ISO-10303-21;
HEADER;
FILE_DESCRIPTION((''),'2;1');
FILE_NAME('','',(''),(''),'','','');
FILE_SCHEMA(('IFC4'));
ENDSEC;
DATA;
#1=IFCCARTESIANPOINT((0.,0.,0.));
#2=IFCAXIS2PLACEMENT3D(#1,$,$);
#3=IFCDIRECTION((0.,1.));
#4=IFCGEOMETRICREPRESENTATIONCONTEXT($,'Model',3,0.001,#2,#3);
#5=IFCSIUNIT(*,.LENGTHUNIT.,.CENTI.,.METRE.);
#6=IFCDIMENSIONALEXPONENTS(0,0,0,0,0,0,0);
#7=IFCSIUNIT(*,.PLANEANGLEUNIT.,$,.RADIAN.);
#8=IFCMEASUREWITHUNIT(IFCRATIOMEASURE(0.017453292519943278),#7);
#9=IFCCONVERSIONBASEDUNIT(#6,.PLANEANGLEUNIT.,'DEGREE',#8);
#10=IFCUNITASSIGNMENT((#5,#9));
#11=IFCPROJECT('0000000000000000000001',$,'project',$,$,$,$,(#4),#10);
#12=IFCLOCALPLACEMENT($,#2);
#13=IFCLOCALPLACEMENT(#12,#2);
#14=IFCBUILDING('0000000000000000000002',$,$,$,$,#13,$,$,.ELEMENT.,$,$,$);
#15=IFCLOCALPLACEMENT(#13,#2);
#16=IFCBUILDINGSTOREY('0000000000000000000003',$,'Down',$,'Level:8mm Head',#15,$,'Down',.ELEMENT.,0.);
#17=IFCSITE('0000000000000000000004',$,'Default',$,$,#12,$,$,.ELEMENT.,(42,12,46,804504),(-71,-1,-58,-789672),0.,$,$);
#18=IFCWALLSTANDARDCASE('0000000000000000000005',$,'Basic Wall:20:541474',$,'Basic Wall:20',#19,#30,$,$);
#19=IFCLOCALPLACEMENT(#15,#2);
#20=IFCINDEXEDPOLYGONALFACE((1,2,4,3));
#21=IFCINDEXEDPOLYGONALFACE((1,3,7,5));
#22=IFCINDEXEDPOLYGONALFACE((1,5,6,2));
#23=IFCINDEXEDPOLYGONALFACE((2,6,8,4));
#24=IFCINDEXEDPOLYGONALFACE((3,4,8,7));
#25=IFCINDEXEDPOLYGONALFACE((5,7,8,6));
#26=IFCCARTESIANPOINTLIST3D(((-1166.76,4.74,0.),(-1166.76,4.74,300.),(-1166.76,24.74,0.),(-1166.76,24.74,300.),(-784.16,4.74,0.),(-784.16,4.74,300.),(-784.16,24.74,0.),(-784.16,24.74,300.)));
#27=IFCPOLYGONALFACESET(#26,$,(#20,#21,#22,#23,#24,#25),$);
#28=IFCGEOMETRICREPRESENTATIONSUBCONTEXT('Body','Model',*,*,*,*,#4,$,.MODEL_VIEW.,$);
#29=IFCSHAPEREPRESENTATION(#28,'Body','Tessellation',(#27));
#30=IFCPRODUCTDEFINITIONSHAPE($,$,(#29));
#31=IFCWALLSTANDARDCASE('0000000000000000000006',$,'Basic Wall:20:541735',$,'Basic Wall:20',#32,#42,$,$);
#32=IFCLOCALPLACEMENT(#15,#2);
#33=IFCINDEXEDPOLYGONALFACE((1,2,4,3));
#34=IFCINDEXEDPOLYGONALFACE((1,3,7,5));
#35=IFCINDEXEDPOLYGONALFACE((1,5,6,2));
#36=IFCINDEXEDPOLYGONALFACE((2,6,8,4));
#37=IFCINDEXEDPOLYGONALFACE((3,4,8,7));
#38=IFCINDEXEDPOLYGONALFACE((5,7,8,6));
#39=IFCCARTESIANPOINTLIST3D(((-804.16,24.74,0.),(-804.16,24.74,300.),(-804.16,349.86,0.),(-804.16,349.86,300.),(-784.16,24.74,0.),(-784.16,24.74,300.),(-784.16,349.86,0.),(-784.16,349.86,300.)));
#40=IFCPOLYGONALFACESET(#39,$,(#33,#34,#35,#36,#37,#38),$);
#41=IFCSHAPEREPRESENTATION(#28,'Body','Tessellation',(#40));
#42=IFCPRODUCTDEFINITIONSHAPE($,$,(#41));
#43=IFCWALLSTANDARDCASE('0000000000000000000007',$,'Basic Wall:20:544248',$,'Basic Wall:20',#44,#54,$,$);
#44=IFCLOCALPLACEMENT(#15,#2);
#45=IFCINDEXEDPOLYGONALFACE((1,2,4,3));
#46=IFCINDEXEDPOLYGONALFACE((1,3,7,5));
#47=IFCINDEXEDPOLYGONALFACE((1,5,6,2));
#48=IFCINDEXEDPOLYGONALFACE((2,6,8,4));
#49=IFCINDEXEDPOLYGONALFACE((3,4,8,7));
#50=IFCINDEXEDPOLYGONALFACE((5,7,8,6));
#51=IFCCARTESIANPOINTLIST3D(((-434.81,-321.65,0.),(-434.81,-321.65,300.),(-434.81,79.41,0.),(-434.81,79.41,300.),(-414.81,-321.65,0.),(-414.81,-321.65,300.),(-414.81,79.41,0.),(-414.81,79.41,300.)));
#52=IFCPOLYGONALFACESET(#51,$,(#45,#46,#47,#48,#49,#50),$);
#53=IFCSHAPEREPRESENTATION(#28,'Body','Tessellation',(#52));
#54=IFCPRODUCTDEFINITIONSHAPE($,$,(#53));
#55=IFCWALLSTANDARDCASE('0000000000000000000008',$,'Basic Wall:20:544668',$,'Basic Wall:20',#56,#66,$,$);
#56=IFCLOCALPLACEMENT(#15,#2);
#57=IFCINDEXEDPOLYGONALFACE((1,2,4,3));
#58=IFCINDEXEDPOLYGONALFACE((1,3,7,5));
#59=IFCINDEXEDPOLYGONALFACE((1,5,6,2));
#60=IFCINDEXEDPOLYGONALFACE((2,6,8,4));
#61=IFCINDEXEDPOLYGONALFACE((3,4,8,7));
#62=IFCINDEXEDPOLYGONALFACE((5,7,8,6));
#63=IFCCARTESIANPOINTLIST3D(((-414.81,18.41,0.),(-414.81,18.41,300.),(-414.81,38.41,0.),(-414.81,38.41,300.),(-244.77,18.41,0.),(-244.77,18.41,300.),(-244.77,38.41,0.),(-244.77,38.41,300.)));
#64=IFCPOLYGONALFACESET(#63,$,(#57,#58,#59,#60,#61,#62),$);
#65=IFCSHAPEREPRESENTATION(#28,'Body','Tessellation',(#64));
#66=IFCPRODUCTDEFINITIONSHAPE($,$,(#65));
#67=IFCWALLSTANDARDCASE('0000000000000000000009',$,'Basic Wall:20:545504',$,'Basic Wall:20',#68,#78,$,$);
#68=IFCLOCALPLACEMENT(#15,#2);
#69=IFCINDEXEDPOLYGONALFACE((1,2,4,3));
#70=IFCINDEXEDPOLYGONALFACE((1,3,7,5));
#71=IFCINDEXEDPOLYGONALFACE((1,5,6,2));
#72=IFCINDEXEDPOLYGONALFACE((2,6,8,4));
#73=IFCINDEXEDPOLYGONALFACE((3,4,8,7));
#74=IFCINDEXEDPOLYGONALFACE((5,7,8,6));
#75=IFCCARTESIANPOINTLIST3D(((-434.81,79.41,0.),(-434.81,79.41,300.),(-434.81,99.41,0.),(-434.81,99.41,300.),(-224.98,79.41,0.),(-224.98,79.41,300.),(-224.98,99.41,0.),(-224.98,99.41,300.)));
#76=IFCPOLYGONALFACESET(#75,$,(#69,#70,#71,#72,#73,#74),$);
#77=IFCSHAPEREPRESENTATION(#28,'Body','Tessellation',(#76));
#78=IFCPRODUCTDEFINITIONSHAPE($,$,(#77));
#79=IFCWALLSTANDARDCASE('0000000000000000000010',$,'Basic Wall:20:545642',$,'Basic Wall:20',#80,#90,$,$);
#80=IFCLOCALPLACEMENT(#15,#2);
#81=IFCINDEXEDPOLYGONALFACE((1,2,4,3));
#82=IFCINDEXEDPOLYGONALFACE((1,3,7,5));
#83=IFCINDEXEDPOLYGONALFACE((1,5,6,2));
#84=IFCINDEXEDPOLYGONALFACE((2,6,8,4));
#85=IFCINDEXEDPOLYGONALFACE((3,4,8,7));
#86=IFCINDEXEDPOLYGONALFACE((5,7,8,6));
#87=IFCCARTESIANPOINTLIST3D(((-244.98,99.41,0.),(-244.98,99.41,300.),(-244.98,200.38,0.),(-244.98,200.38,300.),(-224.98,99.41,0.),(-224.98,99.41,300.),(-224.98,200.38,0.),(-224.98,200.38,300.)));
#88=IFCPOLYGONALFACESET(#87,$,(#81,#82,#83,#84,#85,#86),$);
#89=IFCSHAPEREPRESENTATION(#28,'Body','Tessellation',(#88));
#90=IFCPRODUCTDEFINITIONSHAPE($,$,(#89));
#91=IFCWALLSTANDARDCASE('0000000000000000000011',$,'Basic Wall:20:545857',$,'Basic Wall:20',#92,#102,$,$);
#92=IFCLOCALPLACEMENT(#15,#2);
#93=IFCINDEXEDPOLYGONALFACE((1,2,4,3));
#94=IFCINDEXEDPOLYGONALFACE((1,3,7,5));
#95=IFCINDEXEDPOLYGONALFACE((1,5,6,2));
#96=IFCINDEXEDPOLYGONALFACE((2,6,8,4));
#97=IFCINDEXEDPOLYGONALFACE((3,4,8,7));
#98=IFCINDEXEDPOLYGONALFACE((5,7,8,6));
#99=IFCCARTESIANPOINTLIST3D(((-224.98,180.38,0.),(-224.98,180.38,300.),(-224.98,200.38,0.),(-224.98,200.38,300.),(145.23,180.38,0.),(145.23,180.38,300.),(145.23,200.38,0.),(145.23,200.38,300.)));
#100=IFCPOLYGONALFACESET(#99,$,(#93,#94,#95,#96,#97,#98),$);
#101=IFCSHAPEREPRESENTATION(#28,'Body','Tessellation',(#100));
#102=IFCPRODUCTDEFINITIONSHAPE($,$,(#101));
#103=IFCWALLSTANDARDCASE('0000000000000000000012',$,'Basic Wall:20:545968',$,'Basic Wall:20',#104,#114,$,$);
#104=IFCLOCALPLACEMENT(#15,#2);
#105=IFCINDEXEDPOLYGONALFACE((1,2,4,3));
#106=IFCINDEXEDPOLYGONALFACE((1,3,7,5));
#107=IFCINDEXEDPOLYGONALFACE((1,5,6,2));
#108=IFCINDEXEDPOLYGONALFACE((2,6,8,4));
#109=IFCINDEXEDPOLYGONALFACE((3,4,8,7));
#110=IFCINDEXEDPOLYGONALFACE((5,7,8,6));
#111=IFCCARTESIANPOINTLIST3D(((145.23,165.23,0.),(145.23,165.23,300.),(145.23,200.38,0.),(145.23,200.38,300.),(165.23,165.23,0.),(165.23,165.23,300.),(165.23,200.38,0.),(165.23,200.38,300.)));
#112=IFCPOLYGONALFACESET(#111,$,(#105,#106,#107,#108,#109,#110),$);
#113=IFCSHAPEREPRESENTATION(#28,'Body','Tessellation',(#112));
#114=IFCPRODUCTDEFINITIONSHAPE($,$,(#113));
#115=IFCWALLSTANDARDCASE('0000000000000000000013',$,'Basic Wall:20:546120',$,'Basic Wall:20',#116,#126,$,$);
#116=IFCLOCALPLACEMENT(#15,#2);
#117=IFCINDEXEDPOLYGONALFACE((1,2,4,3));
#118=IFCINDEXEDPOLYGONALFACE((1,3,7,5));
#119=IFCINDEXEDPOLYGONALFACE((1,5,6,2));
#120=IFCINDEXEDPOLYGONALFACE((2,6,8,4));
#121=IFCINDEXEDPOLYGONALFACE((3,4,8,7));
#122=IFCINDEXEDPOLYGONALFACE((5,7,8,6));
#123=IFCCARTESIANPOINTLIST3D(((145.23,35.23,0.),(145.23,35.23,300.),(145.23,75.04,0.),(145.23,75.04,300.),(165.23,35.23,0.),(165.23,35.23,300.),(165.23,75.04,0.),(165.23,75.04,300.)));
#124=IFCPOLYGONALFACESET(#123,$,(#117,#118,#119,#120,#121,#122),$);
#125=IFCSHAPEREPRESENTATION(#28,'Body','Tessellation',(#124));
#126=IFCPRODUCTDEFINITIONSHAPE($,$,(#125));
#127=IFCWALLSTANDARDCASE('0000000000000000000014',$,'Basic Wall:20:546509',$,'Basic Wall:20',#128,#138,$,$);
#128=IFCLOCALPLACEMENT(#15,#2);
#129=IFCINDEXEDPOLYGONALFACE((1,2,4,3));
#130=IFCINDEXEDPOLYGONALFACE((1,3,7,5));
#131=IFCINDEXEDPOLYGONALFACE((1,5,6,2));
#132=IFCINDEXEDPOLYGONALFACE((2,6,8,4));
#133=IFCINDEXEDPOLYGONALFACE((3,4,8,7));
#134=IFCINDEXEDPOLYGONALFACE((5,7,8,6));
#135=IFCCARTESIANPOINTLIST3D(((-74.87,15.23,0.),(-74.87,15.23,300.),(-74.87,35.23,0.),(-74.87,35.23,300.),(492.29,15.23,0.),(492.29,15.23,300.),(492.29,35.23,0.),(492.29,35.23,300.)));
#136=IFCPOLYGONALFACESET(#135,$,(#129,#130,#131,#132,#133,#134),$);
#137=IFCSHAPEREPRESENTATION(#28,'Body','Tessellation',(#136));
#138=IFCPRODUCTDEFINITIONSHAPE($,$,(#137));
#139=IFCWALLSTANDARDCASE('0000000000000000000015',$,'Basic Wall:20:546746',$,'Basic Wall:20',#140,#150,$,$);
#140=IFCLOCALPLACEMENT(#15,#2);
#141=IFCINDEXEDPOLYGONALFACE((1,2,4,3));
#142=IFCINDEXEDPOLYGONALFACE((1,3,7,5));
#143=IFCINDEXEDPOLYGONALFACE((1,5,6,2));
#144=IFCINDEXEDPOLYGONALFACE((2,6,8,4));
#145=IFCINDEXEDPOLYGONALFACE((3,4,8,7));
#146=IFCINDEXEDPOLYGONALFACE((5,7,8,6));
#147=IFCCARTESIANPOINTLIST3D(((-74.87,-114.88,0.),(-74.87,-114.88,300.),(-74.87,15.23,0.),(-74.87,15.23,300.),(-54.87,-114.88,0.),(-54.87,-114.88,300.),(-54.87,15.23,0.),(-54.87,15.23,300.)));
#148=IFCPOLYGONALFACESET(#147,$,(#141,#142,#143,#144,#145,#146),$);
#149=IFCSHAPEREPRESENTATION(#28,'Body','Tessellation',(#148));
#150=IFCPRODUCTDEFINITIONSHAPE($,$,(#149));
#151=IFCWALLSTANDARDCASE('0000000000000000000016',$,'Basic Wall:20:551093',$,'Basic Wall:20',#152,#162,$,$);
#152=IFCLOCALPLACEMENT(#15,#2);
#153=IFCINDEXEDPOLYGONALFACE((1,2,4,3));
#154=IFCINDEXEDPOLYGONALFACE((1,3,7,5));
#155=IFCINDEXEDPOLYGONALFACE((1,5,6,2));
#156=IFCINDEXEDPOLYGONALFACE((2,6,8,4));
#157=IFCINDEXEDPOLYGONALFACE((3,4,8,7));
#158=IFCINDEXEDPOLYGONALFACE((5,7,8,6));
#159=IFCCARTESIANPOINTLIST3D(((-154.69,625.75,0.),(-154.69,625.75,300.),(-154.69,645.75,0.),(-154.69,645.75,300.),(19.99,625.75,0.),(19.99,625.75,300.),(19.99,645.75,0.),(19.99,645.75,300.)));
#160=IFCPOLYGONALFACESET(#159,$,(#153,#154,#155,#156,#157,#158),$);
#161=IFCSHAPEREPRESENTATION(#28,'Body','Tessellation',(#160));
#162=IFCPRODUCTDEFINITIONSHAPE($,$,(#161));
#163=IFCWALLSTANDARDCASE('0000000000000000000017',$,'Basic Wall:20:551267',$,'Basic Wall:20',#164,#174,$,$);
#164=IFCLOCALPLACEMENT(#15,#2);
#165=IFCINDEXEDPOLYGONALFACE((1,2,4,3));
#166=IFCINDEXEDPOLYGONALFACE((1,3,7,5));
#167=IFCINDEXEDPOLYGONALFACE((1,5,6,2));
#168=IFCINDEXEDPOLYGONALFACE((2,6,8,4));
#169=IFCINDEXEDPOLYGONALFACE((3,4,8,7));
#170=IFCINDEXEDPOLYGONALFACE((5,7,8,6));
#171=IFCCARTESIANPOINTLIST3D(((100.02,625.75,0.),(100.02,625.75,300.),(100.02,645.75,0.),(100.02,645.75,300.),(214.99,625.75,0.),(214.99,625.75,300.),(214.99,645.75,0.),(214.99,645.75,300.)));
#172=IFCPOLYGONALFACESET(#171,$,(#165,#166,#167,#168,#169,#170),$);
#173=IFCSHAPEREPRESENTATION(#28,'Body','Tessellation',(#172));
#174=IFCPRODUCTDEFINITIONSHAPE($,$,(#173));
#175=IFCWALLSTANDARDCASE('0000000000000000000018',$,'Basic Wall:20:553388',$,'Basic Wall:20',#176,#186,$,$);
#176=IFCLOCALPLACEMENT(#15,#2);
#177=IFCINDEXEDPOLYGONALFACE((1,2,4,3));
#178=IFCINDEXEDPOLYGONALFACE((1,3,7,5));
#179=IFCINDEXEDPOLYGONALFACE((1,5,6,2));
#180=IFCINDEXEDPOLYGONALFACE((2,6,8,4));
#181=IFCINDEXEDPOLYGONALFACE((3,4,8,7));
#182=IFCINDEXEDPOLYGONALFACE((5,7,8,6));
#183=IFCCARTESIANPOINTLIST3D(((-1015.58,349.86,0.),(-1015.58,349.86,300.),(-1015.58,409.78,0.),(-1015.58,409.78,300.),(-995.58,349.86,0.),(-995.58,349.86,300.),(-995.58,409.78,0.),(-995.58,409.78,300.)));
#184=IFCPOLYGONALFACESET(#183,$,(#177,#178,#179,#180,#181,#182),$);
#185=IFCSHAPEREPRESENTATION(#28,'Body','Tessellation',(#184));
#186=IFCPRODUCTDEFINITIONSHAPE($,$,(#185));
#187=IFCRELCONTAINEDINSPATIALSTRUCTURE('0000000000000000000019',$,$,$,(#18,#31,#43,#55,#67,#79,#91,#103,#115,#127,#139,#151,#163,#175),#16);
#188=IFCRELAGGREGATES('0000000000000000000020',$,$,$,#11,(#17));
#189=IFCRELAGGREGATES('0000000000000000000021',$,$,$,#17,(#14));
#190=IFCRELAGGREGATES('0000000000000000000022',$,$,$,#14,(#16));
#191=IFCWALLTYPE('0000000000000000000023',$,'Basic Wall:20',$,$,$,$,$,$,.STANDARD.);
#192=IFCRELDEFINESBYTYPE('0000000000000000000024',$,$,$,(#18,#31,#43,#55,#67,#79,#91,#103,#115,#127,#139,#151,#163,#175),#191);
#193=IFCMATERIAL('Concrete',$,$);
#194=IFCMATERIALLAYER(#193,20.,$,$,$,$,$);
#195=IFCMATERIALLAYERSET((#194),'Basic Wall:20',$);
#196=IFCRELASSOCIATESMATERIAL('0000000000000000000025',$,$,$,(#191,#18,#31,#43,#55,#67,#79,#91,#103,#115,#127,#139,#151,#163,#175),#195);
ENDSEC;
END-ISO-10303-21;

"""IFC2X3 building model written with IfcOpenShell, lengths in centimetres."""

from ifc_helpers import new_model, entity, si_unit, converted_unit, direction, frame, frame_2d, origin, place, context, subcontext, project, spatial, rectangle, extrude, material, layer, layer_set, layer_usage, type_object, element, save


model = new_model("IFC2X3")

# Units and contexts
model_context = context("Model", 3, precision=0.001, world=origin(), true_north=direction((0.0, 1.0)))
body_context = subcontext(model_context, "Body", "Model", "MODEL_VIEW")
ifc_project = project(units=[si_unit("LENGTHUNIT", "METRE", prefix="CENTI"), converted_unit("PLANEANGLEUNIT", "DEGREE", entity("IfcRatioMeasure", 0.017453292519943278), si_unit("PLANEANGLEUNIT", "RADIAN"), dimensions=[0, 0, 0, 0, 0, 0, 0])], contexts=[model_context])

# Site, building, storey
site_placement = place(None, origin())
site = spatial("IfcSite", under=ifc_project, at=site_placement, Name="Default", CompositionType="ELEMENT", RefLatitude=(42, 12, 46, 804504), RefLongitude=(-71, -1, -58, -789672), RefElevation=0.0)
building_placement = place(site_placement, origin())
building = spatial("IfcBuilding", under=site, at=building_placement, CompositionType="ELEMENT")
storey_placement = place(building_placement, origin())
storey = spatial("IfcBuildingStorey", under=building, at=storey_placement, Name="Down", ObjectType="Level:8mm Head", LongName="Down", CompositionType="ELEMENT", Elevation=0.0)

# Shared definitions
ifc_material = material(Name="Concrete")

# Walls
ifc_layer_1 = layer(ifc_material, 20.0)
ifc_layer_set_1 = layer_set([ifc_layer_1], Name="Basic Wall:20")
ifc_layer_usage_1 = layer_usage(ifc_layer_set_1, "AXIS2", "POSITIVE", -10.0)
wall_type_1 = type_object("IfcWallType", Name="Basic Wall:20", PredefinedType="STANDARD", material=ifc_layer_set_1)
wall_1_placement = place(storey_placement, frame((-1166.76, 14.74, 0.0)))
element("IfcWallStandardCase", 1, at=wall_1_placement, inside=storey, type_object=wall_type_1, material=ifc_layer_usage_1, Name="Basic Wall:20:541474", ObjectType="Basic Wall:20", context=body_context, shape_type="SweptSolid", body=[
    extrude(rectangle(XDim=382.6, YDim=20.0, at=frame_2d((191.3, 0.0), x_axis=(-1.0, 0.0))), origin(), (0.0, 0.0, 1.0), 300.0),
])
ifc_layer_usage_2 = layer_usage(ifc_layer_set_1, "AXIS2", "POSITIVE", -10.0)
wall_2_placement = place(storey_placement, frame((-794.16, 24.74, 0.0), z_axis=(0.0, 0.0, 1.0), x_axis=(0.0, 1.0, 0.0)))
element("IfcWallStandardCase", 2, at=wall_2_placement, inside=storey, type_object=wall_type_1, material=ifc_layer_usage_2, Name="Basic Wall:20:541735", ObjectType="Basic Wall:20", context=body_context, shape_type="SweptSolid", body=[
    extrude(rectangle(XDim=325.12, YDim=20.0, at=frame_2d((162.56, 0.0), x_axis=(-1.0, 0.0))), origin(), (0.0, 0.0, 1.0), 300.0),
])
ifc_layer_usage_3 = layer_usage(ifc_layer_set_1, "AXIS2", "POSITIVE", -10.0)
wall_3_placement = place(storey_placement, frame((-424.81, 79.41, 0.0), z_axis=(0.0, 0.0, 1.0), x_axis=(0.0, -1.0, 0.0)))
element("IfcWallStandardCase", 3, at=wall_3_placement, inside=storey, type_object=wall_type_1, material=ifc_layer_usage_3, Name="Basic Wall:20:544248", ObjectType="Basic Wall:20", context=body_context, shape_type="SweptSolid", body=[
    extrude(rectangle(XDim=401.06, YDim=20.0, at=frame_2d((200.53, 0.0), x_axis=(-1.0, 0.0))), origin(), (0.0, 0.0, 1.0), 300.0),
])
ifc_layer_usage_4 = layer_usage(ifc_layer_set_1, "AXIS2", "POSITIVE", -10.0)
wall_4_placement = place(storey_placement, frame((-244.77, 28.41, 0.0), z_axis=(0.0, 0.0, 1.0), x_axis=(-1.0, 0.0, 0.0)))
element("IfcWallStandardCase", 4, at=wall_4_placement, inside=storey, type_object=wall_type_1, material=ifc_layer_usage_4, Name="Basic Wall:20:544668", ObjectType="Basic Wall:20", context=body_context, shape_type="SweptSolid", body=[
    extrude(rectangle(XDim=170.04, YDim=20.0, at=frame_2d((85.02, 0.0), x_axis=(-1.0, 0.0))), origin(), (0.0, 0.0, 1.0), 300.0),
])
ifc_layer_usage_5 = layer_usage(ifc_layer_set_1, "AXIS2", "NEGATIVE", 10.0)
wall_5_placement = place(storey_placement, frame((-434.81, 89.41, 0.0)))
element("IfcWallStandardCase", 5, at=wall_5_placement, inside=storey, type_object=wall_type_1, material=ifc_layer_usage_5, Name="Basic Wall:20:545504", ObjectType="Basic Wall:20", context=body_context, shape_type="SweptSolid", body=[
    extrude(rectangle(XDim=209.82, YDim=20.0, at=frame_2d((104.91, 0.0), x_axis=(-1.0, 0.0))), origin(), (0.0, 0.0, 1.0), 300.0),
])
ifc_layer_usage_6 = layer_usage(ifc_layer_set_1, "AXIS2", "POSITIVE", -10.0)
wall_6_placement = place(storey_placement, frame((-234.98, 99.41, 0.0), z_axis=(0.0, 0.0, 1.0), x_axis=(0.0, 1.0, 0.0)))
element("IfcWallStandardCase", 6, at=wall_6_placement, inside=storey, type_object=wall_type_1, material=ifc_layer_usage_6, Name="Basic Wall:20:545642", ObjectType="Basic Wall:20", context=body_context, shape_type="SweptSolid", body=[
    extrude(rectangle(XDim=100.97, YDim=20.0, at=frame_2d((50.49, 0.0), x_axis=(-1.0, 0.0))), origin(), (0.0, 0.0, 1.0), 300.0),
])
ifc_layer_usage_7 = layer_usage(ifc_layer_set_1, "AXIS2", "NEGATIVE", 10.0)
wall_7_placement = place(storey_placement, frame((-224.98, 190.38, 0.0)))
element("IfcWallStandardCase", 7, at=wall_7_placement, inside=storey, type_object=wall_type_1, material=ifc_layer_usage_7, Name="Basic Wall:20:545857", ObjectType="Basic Wall:20", context=body_context, shape_type="SweptSolid", body=[
    extrude(rectangle(XDim=370.22, YDim=20.0, at=frame_2d((185.11, 0.0), x_axis=(-1.0, 0.0))), origin(), (0.0, 0.0, 1.0), 300.0),
])
ifc_layer_usage_8 = layer_usage(ifc_layer_set_1, "AXIS2", "NEGATIVE", 10.0)
wall_8_placement = place(storey_placement, frame((155.23, 200.38, 0.0), z_axis=(0.0, 0.0, 1.0), x_axis=(0.0, -1.0, 0.0)))
element("IfcWallStandardCase", 8, at=wall_8_placement, inside=storey, type_object=wall_type_1, material=ifc_layer_usage_8, Name="Basic Wall:20:545968", ObjectType="Basic Wall:20", context=body_context, shape_type="SweptSolid", body=[
    extrude(rectangle(XDim=35.15, YDim=20.0, at=frame_2d((17.57, 0.0), x_axis=(-1.0, 0.0))), origin(), (0.0, 0.0, 1.0), 300.0),
])
ifc_layer_usage_9 = layer_usage(ifc_layer_set_1, "AXIS2", "NEGATIVE", 10.0)
wall_9_placement = place(storey_placement, frame((155.23, 75.04, 0.0), z_axis=(0.0, 0.0, 1.0), x_axis=(0.0, -1.0, 0.0)))
element("IfcWallStandardCase", 9, at=wall_9_placement, inside=storey, type_object=wall_type_1, material=ifc_layer_usage_9, Name="Basic Wall:20:546120", ObjectType="Basic Wall:20", context=body_context, shape_type="SweptSolid", body=[
    extrude(rectangle(XDim=39.81, YDim=20.0, at=frame_2d((19.9, 0.0), x_axis=(-1.0, 0.0))), origin(), (0.0, 0.0, 1.0), 300.0),
])
ifc_layer_usage_10 = layer_usage(ifc_layer_set_1, "AXIS2", "NEGATIVE", 10.0)
wall_10_placement = place(storey_placement, frame((-74.87, 25.23, 0.0)))
element("IfcWallStandardCase", 10, at=wall_10_placement, inside=storey, type_object=wall_type_1, material=ifc_layer_usage_10, Name="Basic Wall:20:546509", ObjectType="Basic Wall:20", context=body_context, shape_type="SweptSolid", body=[
    extrude(rectangle(XDim=567.15, YDim=20.0, at=frame_2d((283.58, 0.0), x_axis=(-1.0, 0.0))), origin(), (0.0, 0.0, 1.0), 300.0),
])
ifc_layer_usage_11 = layer_usage(ifc_layer_set_1, "AXIS2", "POSITIVE", -10.0)
wall_11_placement = place(storey_placement, frame((-64.87, 15.23, 0.0), z_axis=(0.0, 0.0, 1.0), x_axis=(0.0, -1.0, 0.0)))
element("IfcWallStandardCase", 11, at=wall_11_placement, inside=storey, type_object=wall_type_1, material=ifc_layer_usage_11, Name="Basic Wall:20:546746", ObjectType="Basic Wall:20", context=body_context, shape_type="SweptSolid", body=[
    extrude(rectangle(XDim=130.12, YDim=20.0, at=frame_2d((65.06, 0.0), x_axis=(-1.0, 0.0))), origin(), (0.0, 0.0, 1.0), 300.0),
])
ifc_layer_usage_12 = layer_usage(ifc_layer_set_1, "AXIS2", "POSITIVE", -10.0)
wall_12_placement = place(storey_placement, frame((-154.69, 635.75, 0.0)))
element("IfcWallStandardCase", 12, at=wall_12_placement, inside=storey, type_object=wall_type_1, material=ifc_layer_usage_12, Name="Basic Wall:20:551093", ObjectType="Basic Wall:20", context=body_context, shape_type="SweptSolid", body=[
    extrude(rectangle(XDim=174.68, YDim=20.0, at=frame_2d((87.34, 0.0), x_axis=(-1.0, 0.0))), origin(), (0.0, 0.0, 1.0), 300.0),
])
ifc_layer_usage_13 = layer_usage(ifc_layer_set_1, "AXIS2", "POSITIVE", -10.0)
wall_13_placement = place(storey_placement, frame((100.02, 635.75, 0.0)))
element("IfcWallStandardCase", 13, at=wall_13_placement, inside=storey, type_object=wall_type_1, material=ifc_layer_usage_13, Name="Basic Wall:20:551267", ObjectType="Basic Wall:20", context=body_context, shape_type="SweptSolid", body=[
    extrude(rectangle(XDim=114.97, YDim=20.0, at=frame_2d((57.48, 0.0), x_axis=(-1.0, 0.0))), origin(), (0.0, 0.0, 1.0), 300.0),
])
ifc_layer_usage_14 = layer_usage(ifc_layer_set_1, "AXIS2", "NEGATIVE", 10.0)
wall_14_placement = place(storey_placement, frame((-1005.58, 349.86, 0.0), z_axis=(0.0, 0.0, 1.0), x_axis=(0.0, 1.0, 0.0)))
element("IfcWallStandardCase", 14, at=wall_14_placement, inside=storey, type_object=wall_type_1, material=ifc_layer_usage_14, Name="Basic Wall:20:553388", ObjectType="Basic Wall:20", context=body_context, shape_type="SweptSolid", body=[
    extrude(rectangle(XDim=59.92, YDim=20.0, at=frame_2d((29.96, 0.0), x_axis=(-1.0, 0.0))), origin(), (0.0, 0.0, 1.0), 300.0),
])

save(model, "model.ifc")
